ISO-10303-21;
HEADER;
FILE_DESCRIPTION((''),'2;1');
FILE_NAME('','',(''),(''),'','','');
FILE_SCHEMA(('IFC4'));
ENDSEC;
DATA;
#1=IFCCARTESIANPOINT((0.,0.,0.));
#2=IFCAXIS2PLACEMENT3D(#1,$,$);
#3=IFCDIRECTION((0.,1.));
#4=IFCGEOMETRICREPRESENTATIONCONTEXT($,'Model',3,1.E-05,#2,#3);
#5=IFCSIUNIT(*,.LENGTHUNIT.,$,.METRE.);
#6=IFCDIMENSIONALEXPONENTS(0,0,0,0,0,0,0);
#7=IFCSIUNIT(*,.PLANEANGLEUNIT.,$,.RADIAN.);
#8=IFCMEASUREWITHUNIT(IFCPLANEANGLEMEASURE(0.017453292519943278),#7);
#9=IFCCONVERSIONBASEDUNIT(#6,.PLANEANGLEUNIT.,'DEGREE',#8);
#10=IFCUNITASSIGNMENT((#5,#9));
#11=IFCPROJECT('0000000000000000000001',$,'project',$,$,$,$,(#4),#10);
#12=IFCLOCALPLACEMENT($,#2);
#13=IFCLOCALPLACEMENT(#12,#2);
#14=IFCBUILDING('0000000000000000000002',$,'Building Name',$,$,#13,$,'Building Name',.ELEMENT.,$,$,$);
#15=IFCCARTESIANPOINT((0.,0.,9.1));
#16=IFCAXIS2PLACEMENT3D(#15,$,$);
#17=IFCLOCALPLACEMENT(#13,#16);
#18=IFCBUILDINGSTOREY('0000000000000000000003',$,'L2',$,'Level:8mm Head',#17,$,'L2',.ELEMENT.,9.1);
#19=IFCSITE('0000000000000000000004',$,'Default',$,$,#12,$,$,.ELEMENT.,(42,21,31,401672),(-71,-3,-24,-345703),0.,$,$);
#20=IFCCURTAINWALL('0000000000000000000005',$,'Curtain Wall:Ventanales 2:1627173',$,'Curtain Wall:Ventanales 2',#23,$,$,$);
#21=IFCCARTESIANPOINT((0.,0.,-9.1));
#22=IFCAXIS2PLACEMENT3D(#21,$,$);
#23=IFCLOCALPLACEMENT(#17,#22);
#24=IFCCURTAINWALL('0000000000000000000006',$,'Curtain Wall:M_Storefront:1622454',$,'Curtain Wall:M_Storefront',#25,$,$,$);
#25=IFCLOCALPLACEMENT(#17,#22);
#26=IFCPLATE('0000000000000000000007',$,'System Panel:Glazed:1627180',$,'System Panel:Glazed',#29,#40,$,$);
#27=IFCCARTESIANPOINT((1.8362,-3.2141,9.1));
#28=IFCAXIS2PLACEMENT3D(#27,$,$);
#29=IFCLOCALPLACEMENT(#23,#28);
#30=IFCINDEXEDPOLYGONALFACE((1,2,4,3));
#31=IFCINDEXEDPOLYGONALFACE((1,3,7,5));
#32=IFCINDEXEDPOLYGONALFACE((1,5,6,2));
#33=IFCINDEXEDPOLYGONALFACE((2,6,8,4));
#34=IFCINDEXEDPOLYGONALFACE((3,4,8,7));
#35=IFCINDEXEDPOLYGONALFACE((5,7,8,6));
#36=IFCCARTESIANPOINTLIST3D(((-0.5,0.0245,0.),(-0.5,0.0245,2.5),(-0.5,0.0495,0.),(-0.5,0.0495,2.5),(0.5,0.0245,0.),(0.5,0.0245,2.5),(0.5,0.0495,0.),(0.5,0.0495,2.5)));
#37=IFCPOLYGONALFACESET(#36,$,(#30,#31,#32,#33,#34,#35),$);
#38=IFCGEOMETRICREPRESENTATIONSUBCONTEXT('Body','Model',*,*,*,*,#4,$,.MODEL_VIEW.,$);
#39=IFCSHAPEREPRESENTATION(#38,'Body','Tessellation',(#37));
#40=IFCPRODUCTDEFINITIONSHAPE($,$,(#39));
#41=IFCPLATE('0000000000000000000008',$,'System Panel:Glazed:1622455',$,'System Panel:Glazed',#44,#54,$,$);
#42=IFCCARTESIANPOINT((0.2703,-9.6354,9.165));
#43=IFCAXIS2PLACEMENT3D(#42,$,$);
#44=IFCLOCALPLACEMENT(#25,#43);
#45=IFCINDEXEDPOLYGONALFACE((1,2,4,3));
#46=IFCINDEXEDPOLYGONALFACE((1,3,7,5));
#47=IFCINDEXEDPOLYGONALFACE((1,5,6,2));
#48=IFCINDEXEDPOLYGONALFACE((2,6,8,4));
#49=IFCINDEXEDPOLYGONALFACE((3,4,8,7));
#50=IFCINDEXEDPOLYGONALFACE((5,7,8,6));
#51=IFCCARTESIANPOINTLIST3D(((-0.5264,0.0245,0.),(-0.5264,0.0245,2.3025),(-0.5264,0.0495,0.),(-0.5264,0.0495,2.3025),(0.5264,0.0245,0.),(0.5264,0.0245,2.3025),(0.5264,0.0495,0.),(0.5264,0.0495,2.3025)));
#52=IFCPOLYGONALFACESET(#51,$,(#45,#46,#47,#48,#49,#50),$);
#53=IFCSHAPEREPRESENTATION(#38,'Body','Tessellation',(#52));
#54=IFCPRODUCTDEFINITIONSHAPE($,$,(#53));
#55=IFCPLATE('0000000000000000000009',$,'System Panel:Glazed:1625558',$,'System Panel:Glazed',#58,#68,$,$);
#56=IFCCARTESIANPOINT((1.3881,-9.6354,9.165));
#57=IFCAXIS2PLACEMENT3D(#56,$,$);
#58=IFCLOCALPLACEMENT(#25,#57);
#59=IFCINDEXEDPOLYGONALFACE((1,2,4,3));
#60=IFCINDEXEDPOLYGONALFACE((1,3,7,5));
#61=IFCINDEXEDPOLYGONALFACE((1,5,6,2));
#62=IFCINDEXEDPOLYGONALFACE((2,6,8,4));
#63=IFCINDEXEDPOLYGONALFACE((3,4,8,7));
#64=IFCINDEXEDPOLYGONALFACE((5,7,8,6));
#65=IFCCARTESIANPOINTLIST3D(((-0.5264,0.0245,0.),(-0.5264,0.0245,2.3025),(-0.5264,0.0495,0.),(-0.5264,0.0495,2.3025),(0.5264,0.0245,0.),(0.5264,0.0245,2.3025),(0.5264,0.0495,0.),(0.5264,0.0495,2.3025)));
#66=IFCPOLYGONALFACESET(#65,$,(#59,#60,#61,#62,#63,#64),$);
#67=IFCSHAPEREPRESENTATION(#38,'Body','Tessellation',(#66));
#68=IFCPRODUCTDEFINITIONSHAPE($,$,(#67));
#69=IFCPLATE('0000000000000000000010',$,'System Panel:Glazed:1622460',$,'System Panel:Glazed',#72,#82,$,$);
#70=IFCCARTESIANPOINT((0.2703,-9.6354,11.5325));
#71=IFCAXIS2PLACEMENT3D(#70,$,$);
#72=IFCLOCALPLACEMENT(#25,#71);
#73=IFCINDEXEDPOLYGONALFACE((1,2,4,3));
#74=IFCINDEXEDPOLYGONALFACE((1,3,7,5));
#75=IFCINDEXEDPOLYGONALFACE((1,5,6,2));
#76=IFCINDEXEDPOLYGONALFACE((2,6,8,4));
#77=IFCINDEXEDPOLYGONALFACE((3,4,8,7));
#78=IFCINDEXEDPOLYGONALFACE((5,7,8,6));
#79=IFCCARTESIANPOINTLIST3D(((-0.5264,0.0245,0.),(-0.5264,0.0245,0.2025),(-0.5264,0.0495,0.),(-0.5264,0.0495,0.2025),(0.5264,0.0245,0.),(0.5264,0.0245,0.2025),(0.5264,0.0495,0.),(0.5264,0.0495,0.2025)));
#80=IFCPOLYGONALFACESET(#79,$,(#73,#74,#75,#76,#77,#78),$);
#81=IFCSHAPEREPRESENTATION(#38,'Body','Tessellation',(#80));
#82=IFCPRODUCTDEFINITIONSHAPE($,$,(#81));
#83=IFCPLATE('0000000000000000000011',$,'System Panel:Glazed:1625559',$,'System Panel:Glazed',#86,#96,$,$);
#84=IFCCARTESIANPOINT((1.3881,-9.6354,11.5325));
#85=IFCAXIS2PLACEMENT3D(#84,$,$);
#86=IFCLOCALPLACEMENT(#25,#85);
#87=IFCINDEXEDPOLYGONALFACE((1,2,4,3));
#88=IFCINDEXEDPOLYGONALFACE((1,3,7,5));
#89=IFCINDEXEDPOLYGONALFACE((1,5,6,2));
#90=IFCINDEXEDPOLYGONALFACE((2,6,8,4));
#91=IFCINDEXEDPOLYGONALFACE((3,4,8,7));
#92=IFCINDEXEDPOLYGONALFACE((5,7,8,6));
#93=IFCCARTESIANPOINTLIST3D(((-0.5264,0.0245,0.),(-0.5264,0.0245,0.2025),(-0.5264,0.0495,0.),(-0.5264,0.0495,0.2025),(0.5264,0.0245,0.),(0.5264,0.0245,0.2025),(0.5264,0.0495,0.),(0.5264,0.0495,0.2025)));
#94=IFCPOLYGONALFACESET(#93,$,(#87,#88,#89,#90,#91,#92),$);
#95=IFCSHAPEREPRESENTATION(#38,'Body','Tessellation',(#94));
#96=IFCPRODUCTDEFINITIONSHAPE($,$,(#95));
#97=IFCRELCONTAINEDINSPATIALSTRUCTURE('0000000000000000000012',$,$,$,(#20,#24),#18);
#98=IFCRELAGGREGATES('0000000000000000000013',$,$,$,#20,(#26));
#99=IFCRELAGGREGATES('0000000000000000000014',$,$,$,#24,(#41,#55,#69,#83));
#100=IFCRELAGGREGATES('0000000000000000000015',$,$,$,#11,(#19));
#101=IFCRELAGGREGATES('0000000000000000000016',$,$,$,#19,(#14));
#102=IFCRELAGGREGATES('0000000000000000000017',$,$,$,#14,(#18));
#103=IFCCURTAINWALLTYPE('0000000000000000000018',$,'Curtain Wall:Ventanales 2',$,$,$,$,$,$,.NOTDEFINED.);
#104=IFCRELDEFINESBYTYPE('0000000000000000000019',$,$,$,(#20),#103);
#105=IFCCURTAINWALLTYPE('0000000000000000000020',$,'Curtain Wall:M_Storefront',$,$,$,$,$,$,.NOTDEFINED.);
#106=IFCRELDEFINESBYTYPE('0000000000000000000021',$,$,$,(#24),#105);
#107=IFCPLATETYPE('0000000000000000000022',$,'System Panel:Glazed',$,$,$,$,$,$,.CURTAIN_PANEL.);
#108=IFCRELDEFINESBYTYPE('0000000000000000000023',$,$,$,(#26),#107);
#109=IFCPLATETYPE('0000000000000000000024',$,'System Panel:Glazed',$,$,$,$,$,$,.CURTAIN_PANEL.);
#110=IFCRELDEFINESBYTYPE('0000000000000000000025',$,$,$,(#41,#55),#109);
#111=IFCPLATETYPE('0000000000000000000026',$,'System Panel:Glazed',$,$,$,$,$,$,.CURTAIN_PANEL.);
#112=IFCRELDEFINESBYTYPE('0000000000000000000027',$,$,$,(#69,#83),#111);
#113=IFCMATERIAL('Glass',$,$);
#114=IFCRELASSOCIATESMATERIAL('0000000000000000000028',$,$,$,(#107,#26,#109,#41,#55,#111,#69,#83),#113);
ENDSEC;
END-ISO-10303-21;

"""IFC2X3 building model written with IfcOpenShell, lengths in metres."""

from ifc_helpers import new_model, entity, si_unit, converted_unit, direction, frame, frame_2d, origin, origin_2d_with_axis, place, context, subcontext, project, spatial, rectangle, extrude, source, transform, mapped, material, type_object, type_shapes, element, aggregate, save


model = new_model("IFC2X3")

# Units and contexts
model_context = context("Model", 3, precision=1e-05, world=origin(), true_north=direction((0.0, 1.0)))
body_context = subcontext(model_context, "Body", "Model", "MODEL_VIEW")
ifc_project = project(units=[si_unit("LENGTHUNIT", "METRE"), converted_unit("PLANEANGLEUNIT", "DEGREE", entity("IfcPlaneAngleMeasure", 0.017453292519943278), si_unit("PLANEANGLEUNIT", "RADIAN"), dimensions=[0, 0, 0, 0, 0, 0, 0])], contexts=[model_context])

# Site, building, storey
site_placement = place(None, origin())
site = spatial("IfcSite", under=ifc_project, at=site_placement, Name="Default", CompositionType="ELEMENT", RefLatitude=(42, 21, 31, 401672), RefLongitude=(-71, -3, -24, -345703), RefElevation=0.0)
building_placement = place(site_placement, origin())
building = spatial("IfcBuilding", under=site, at=building_placement, Name="Building Name", LongName="Building Name", CompositionType="ELEMENT")
storey_placement = place(building_placement, frame((0.0, 0.0, 9.1)))
storey = spatial("IfcBuildingStorey", under=building, at=storey_placement, Name="L2", ObjectType="Level:8mm Head", LongName="L2", CompositionType="ELEMENT", Elevation=9.1)

# Curtain wall
curtain_wall_type_1 = type_object("IfcCurtainWallType", Name="Curtain Wall:Ventanales 2", PredefinedType="NOTDEFINED")
curtain_wall_1_placement = place(storey_placement, frame((0.0, 0.0, -9.1)))
curtain_wall_1 = element("IfcCurtainWall", 1, at=curtain_wall_1_placement, inside=storey, type_object=curtain_wall_type_1, Name="Curtain Wall:Ventanales 2:1627173", ObjectType="Curtain Wall:Ventanales 2")

# Curtain wall
curtain_wall_type_2 = type_object("IfcCurtainWallType", Name="Curtain Wall:M_Storefront", PredefinedType="NOTDEFINED")
curtain_wall_2_placement = place(storey_placement, frame((0.0, 0.0, -9.1)))
curtain_wall_2 = element("IfcCurtainWall", 2, at=curtain_wall_2_placement, inside=storey, type_object=curtain_wall_type_2, Name="Curtain Wall:M_Storefront:1622454", ObjectType="Curtain Wall:M_Storefront")

# Plates
ifc_material_1 = material(Name="Glass")
plate_type_1 = type_object("IfcPlateType", Name="System Panel:Glazed", PredefinedType="CURTAIN_PANEL", material=ifc_material_1)
shared_shape_1 = source(origin(), body_context, "Body", "SweptSolid", [
    extrude(rectangle(XDim=0.025, YDim=1.0, at=origin_2d_with_axis()), frame((0.0, 0.037, 0.0), z_axis=(0.0, 0.0, 1.0), x_axis=(0.0, 1.0, 0.0)), (0.0, 0.0, 1.0), 2.5),
])
type_shapes(plate_type_1, [shared_shape_1])
plate_1_placement = place(curtain_wall_1_placement, frame((1.8362, -3.2141, 9.1)))
plate_1 = element("IfcPlate", 3, at=plate_1_placement, type_object=plate_type_1, material=ifc_material_1, Name="System Panel:Glazed:1627180", ObjectType="System Panel:Glazed", context=body_context, shape_type="MappedRepresentation", body=[
    mapped(shared_shape_1, transform((0.0, 0.0, 0.0), scale=1.0)),
])
aggregate(curtain_wall_1, [plate_1])
plate_type_2 = type_object("IfcPlateType", Name="System Panel:Glazed", PredefinedType="CURTAIN_PANEL", material=ifc_material_1)
shared_shape_2 = source(origin(), body_context, "Body", "SweptSolid", [
    extrude(rectangle(XDim=0.025, YDim=1.0528, at=frame_2d((0.0, 0.0), x_axis=(1.0, 0.0))), frame((0.0, 0.037, 0.0), z_axis=(0.0, 0.0, 1.0), x_axis=(0.0, 1.0, 0.0)), (0.0, 0.0, 1.0), 2.3025),
])
type_shapes(plate_type_2, [shared_shape_2])
plate_2_placement = place(curtain_wall_2_placement, frame((0.2703, -9.6354, 9.165)))
plate_2 = element("IfcPlate", 4, at=plate_2_placement, type_object=plate_type_2, material=ifc_material_1, Name="System Panel:Glazed:1622455", ObjectType="System Panel:Glazed", context=body_context, shape_type="MappedRepresentation", body=[
    mapped(shared_shape_2, transform((0.0, 0.0, 0.0), scale=1.0)),
])
plate_3_placement = place(curtain_wall_2_placement, frame((1.3881, -9.6354, 9.165)))
plate_3 = element("IfcPlate", 5, at=plate_3_placement, type_object=plate_type_2, material=ifc_material_1, Name="System Panel:Glazed:1625558", ObjectType="System Panel:Glazed", context=body_context, shape_type="MappedRepresentation", body=[
    mapped(shared_shape_2, transform((0.0, 0.0, 0.0), scale=1.0)),
])
plate_type_3 = type_object("IfcPlateType", Name="System Panel:Glazed", PredefinedType="CURTAIN_PANEL", material=ifc_material_1)
shared_shape_3 = source(origin(), body_context, "Body", "SweptSolid", [
    extrude(rectangle(XDim=0.025, YDim=1.0528, at=frame_2d((0.0, 0.0), x_axis=(1.0, 0.0))), frame((0.0, 0.037, 0.0), z_axis=(0.0, 0.0, 1.0), x_axis=(0.0, 1.0, 0.0)), (0.0, 0.0, 1.0), 0.2025),
])
type_shapes(plate_type_3, [shared_shape_3])
plate_4_placement = place(curtain_wall_2_placement, frame((0.2703, -9.6354, 11.5325)))
plate_4 = element("IfcPlate", 6, at=plate_4_placement, type_object=plate_type_3, material=ifc_material_1, Name="System Panel:Glazed:1622460", ObjectType="System Panel:Glazed", context=body_context, shape_type="MappedRepresentation", body=[
    mapped(shared_shape_3, transform((0.0, 0.0, 0.0), scale=1.0)),
])
plate_5_placement = place(curtain_wall_2_placement, frame((1.3881, -9.6354, 11.5325)))
plate_5 = element("IfcPlate", 7, at=plate_5_placement, type_object=plate_type_3, material=ifc_material_1, Name="System Panel:Glazed:1625559", ObjectType="System Panel:Glazed", context=body_context, shape_type="MappedRepresentation", body=[
    mapped(shared_shape_3, transform((0.0, 0.0, 0.0), scale=1.0)),
])
aggregate(curtain_wall_2, [plate_2, plate_3, plate_4, plate_5])

save(model, "model.ifc")
